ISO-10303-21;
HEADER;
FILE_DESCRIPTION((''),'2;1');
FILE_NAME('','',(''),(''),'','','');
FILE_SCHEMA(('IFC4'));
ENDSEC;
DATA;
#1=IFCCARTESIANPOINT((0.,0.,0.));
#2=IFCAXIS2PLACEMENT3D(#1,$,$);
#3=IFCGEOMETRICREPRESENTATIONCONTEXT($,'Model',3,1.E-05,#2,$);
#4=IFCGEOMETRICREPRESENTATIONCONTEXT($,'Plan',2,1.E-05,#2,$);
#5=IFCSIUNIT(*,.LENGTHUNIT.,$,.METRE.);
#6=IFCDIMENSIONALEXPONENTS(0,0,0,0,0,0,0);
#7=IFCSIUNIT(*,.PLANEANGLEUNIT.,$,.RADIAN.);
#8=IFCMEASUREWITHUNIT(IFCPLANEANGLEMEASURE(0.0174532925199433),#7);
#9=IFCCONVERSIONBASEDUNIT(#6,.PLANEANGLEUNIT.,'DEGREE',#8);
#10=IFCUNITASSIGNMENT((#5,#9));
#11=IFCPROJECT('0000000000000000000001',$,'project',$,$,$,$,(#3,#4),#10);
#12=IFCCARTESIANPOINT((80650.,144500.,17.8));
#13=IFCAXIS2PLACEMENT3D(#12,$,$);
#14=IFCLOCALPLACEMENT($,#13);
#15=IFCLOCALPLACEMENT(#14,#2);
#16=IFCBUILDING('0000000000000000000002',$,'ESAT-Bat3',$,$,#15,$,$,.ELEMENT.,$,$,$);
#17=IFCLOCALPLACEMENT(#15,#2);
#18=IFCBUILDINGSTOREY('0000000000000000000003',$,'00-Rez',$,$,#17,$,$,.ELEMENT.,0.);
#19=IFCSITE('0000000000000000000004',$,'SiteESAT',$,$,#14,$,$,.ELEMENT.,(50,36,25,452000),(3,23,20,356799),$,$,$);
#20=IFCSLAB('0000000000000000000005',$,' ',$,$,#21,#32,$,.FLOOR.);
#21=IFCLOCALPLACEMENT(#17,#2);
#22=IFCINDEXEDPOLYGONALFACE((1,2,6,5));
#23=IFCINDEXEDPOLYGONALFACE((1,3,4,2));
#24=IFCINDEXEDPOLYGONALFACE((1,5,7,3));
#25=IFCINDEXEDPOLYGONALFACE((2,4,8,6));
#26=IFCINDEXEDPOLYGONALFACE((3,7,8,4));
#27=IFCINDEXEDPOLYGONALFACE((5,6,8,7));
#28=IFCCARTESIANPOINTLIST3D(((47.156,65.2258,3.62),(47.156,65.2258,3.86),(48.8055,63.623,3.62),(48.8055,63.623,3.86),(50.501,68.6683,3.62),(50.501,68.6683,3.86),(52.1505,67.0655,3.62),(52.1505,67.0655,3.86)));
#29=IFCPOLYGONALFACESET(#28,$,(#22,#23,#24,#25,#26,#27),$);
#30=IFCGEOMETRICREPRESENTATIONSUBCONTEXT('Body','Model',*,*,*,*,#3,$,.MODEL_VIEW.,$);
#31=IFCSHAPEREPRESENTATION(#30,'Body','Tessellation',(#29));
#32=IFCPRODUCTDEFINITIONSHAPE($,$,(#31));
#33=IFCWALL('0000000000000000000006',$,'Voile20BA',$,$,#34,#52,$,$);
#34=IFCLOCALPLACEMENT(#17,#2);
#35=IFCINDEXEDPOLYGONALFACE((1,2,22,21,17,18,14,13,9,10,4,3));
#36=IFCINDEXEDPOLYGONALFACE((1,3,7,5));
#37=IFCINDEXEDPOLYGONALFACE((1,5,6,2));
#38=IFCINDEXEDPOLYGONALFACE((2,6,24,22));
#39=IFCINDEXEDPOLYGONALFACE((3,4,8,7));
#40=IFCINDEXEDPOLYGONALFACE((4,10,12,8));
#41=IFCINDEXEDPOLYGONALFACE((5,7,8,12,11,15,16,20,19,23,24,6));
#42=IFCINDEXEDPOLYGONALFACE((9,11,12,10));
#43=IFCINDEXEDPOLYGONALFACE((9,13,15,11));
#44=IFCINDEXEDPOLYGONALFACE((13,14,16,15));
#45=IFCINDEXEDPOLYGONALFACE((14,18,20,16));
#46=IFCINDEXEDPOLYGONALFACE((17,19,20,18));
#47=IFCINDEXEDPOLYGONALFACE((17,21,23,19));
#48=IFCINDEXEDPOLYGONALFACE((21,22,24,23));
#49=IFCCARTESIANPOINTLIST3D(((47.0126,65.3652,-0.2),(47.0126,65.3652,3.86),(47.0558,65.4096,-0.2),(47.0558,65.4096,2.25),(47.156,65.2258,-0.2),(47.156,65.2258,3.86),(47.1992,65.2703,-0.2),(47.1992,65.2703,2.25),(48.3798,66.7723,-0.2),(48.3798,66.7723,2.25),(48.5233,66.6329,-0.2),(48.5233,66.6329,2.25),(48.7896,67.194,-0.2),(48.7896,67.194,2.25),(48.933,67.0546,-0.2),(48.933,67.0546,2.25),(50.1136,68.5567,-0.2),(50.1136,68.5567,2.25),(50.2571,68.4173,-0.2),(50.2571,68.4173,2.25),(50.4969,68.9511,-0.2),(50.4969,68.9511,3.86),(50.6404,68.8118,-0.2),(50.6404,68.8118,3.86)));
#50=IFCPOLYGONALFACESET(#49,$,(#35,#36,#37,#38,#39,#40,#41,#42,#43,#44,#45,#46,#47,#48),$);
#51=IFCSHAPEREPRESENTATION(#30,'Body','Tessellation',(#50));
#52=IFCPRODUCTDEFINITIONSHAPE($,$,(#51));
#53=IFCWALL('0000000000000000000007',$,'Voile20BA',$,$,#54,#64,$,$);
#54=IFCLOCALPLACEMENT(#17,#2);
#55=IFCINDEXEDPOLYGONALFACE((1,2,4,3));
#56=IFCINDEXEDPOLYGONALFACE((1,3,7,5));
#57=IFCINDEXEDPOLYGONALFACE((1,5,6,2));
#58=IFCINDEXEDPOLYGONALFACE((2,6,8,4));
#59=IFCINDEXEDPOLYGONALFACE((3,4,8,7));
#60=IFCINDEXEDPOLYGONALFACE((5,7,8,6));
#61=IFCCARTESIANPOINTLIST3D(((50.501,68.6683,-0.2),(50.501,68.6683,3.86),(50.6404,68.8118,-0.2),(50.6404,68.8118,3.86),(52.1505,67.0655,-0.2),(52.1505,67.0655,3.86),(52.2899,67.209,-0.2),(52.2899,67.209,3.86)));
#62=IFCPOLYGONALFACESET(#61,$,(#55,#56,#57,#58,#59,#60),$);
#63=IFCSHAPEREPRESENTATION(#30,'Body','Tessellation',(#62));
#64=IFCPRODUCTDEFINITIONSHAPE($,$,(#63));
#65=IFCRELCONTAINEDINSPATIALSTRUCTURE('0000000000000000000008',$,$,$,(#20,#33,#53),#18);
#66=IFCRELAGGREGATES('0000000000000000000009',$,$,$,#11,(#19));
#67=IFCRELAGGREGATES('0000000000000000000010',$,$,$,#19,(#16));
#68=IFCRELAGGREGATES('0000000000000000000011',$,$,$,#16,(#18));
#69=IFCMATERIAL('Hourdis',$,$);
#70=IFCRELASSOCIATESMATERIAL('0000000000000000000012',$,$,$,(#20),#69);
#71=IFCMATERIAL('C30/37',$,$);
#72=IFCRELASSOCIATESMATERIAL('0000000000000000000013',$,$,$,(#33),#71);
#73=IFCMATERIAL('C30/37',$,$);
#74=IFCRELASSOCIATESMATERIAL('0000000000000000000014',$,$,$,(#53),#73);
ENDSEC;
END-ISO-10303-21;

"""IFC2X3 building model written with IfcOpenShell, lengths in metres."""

from ifc_helpers import new_model, entity, si_unit, converted_unit, frame, frame_2d, origin, origin_with_axes, place, context, subcontext, project, spatial, polyline, rectangle, outline, extrude, material, element, save


model = new_model("IFC2X3")

# Units and contexts
model_context = context("Model", 3, precision=1e-05, world=origin())
plan_context = context("Plan", 2, precision=1e-05, world=origin())
body_context = subcontext(model_context, "Body", "Model", "MODEL_VIEW")
ifc_project = project(units=[si_unit("LENGTHUNIT", "METRE"), converted_unit("PLANEANGLEUNIT", "DEGREE", entity("IfcPlaneAngleMeasure", 0.0174532925199433), si_unit("PLANEANGLEUNIT", "RADIAN"), dimensions=[0, 0, 0, 0, 0, 0, 0])], contexts=[model_context, plan_context])

# Site, building, storey
site_placement = place(None, frame((80650.0, 144500.0, 17.8)))
site = spatial("IfcSite", under=ifc_project, at=site_placement, Name="SiteESAT", CompositionType="ELEMENT", RefLatitude=(50, 36, 25, 452000), RefLongitude=(3, 23, 20, 356799))
building_placement = place(site_placement, origin())
building = spatial("IfcBuilding", under=site, at=building_placement, Name="ESAT-Bat3", CompositionType="ELEMENT")
storey_placement = place(building_placement, origin())
storey = spatial("IfcBuildingStorey", under=building, at=storey_placement, Name="00-Rez", CompositionType="ELEMENT", Elevation=0.0)

# Slab
ifc_material_1 = material(Name="Hourdis")
slab_placement = place(storey_placement, frame((47.156, 63.623, 3.62)))
element("IfcSlab", 1, at=slab_placement, inside=storey, material=ifc_material_1, Name=" ", PredefinedType="FLOOR", context=body_context, shape_type="SweptSolid", body=[
    extrude(rectangle(XDim=4.8, YDim=2.3, at=frame_2d((-0.8477, -2.5227), x_axis=(-0.696872, -0.717196))), frame((3.345, 5.0453, 0.0), z_axis=(0.0, 0.0, 1.0), x_axis=(1.0, 0.0, 0.0)), (0.0, 0.0, 1.0), 0.24),
])

# Wall, openings
ifc_material_2 = material(Name="C30/37")
wall_1_placement = place(storey_placement, frame((50.4969, 68.9511, -0.2), z_axis=(0.0, 0.0, 1.0), x_axis=(-0.696872, -0.717196, 0.0)))
wall_1 = element("IfcWall", 2, at=wall_1_placement, inside=storey, material=ifc_material_2, Name="Voile20BA", context=body_context, shape_type="SweptSolid", body=[
    extrude(rectangle(XDim=5.0, YDim=0.2, at=frame_2d((2.5, 0.1), x_axis=(1.0, 0.0))), origin_with_axes(), (0.0, 0.0, 1.0), 4.06),
])
opening_1_placement = place(wall_1_placement, frame((4.938, 0.2, 0.0), z_axis=(0.0, -1.0, 0.0), x_axis=(0.0, 0.0, 1.0)))
element("IfcOpeningElement", 3, at=opening_1_placement, cuts=wall_1, ObjectType="Opening", context=body_context, shape_type="SweptSolid", body=[
    extrude(outline(polyline([(0.0, 1.9), (2.45, 1.9), (2.45, 0.0), (0.0, 0.0), (0.0, 1.9)])), origin_with_axes(), (0.0, 0.0, 1.0), 0.2),
])
opening_2_placement = place(wall_1_placement, frame((2.45, 0.2, 0.0), z_axis=(0.0, -1.0, 0.0), x_axis=(0.0, 0.0, 1.0)))
element("IfcOpeningElement", 4, at=opening_2_placement, cuts=wall_1, ObjectType="Opening", context=body_context, shape_type="SweptSolid", body=[
    extrude(outline(polyline([(0.0, 1.9), (2.45, 1.9), (2.45, 0.0), (0.0, 0.0), (0.0, 1.9)])), origin_with_axes(), (0.0, 0.0, 1.0), 0.2),
])

# Wall
ifc_material_3 = material(Name="C30/37")
wall_2_placement = place(storey_placement, frame((52.2899, 67.209, -0.2), z_axis=(0.0, 0.0, 1.0), x_axis=(-0.717196, 0.696872, 0.0)))
element("IfcWall", 5, at=wall_2_placement, inside=storey, material=ifc_material_3, Name="Voile20BA", context=body_context, shape_type="SweptSolid", body=[
    extrude(rectangle(XDim=2.3, YDim=0.2, at=frame_2d((1.15, 0.1), x_axis=(1.0, 0.0))), origin_with_axes(), (0.0, 0.0, 1.0), 4.06),
])

save(model, "model.ifc")
